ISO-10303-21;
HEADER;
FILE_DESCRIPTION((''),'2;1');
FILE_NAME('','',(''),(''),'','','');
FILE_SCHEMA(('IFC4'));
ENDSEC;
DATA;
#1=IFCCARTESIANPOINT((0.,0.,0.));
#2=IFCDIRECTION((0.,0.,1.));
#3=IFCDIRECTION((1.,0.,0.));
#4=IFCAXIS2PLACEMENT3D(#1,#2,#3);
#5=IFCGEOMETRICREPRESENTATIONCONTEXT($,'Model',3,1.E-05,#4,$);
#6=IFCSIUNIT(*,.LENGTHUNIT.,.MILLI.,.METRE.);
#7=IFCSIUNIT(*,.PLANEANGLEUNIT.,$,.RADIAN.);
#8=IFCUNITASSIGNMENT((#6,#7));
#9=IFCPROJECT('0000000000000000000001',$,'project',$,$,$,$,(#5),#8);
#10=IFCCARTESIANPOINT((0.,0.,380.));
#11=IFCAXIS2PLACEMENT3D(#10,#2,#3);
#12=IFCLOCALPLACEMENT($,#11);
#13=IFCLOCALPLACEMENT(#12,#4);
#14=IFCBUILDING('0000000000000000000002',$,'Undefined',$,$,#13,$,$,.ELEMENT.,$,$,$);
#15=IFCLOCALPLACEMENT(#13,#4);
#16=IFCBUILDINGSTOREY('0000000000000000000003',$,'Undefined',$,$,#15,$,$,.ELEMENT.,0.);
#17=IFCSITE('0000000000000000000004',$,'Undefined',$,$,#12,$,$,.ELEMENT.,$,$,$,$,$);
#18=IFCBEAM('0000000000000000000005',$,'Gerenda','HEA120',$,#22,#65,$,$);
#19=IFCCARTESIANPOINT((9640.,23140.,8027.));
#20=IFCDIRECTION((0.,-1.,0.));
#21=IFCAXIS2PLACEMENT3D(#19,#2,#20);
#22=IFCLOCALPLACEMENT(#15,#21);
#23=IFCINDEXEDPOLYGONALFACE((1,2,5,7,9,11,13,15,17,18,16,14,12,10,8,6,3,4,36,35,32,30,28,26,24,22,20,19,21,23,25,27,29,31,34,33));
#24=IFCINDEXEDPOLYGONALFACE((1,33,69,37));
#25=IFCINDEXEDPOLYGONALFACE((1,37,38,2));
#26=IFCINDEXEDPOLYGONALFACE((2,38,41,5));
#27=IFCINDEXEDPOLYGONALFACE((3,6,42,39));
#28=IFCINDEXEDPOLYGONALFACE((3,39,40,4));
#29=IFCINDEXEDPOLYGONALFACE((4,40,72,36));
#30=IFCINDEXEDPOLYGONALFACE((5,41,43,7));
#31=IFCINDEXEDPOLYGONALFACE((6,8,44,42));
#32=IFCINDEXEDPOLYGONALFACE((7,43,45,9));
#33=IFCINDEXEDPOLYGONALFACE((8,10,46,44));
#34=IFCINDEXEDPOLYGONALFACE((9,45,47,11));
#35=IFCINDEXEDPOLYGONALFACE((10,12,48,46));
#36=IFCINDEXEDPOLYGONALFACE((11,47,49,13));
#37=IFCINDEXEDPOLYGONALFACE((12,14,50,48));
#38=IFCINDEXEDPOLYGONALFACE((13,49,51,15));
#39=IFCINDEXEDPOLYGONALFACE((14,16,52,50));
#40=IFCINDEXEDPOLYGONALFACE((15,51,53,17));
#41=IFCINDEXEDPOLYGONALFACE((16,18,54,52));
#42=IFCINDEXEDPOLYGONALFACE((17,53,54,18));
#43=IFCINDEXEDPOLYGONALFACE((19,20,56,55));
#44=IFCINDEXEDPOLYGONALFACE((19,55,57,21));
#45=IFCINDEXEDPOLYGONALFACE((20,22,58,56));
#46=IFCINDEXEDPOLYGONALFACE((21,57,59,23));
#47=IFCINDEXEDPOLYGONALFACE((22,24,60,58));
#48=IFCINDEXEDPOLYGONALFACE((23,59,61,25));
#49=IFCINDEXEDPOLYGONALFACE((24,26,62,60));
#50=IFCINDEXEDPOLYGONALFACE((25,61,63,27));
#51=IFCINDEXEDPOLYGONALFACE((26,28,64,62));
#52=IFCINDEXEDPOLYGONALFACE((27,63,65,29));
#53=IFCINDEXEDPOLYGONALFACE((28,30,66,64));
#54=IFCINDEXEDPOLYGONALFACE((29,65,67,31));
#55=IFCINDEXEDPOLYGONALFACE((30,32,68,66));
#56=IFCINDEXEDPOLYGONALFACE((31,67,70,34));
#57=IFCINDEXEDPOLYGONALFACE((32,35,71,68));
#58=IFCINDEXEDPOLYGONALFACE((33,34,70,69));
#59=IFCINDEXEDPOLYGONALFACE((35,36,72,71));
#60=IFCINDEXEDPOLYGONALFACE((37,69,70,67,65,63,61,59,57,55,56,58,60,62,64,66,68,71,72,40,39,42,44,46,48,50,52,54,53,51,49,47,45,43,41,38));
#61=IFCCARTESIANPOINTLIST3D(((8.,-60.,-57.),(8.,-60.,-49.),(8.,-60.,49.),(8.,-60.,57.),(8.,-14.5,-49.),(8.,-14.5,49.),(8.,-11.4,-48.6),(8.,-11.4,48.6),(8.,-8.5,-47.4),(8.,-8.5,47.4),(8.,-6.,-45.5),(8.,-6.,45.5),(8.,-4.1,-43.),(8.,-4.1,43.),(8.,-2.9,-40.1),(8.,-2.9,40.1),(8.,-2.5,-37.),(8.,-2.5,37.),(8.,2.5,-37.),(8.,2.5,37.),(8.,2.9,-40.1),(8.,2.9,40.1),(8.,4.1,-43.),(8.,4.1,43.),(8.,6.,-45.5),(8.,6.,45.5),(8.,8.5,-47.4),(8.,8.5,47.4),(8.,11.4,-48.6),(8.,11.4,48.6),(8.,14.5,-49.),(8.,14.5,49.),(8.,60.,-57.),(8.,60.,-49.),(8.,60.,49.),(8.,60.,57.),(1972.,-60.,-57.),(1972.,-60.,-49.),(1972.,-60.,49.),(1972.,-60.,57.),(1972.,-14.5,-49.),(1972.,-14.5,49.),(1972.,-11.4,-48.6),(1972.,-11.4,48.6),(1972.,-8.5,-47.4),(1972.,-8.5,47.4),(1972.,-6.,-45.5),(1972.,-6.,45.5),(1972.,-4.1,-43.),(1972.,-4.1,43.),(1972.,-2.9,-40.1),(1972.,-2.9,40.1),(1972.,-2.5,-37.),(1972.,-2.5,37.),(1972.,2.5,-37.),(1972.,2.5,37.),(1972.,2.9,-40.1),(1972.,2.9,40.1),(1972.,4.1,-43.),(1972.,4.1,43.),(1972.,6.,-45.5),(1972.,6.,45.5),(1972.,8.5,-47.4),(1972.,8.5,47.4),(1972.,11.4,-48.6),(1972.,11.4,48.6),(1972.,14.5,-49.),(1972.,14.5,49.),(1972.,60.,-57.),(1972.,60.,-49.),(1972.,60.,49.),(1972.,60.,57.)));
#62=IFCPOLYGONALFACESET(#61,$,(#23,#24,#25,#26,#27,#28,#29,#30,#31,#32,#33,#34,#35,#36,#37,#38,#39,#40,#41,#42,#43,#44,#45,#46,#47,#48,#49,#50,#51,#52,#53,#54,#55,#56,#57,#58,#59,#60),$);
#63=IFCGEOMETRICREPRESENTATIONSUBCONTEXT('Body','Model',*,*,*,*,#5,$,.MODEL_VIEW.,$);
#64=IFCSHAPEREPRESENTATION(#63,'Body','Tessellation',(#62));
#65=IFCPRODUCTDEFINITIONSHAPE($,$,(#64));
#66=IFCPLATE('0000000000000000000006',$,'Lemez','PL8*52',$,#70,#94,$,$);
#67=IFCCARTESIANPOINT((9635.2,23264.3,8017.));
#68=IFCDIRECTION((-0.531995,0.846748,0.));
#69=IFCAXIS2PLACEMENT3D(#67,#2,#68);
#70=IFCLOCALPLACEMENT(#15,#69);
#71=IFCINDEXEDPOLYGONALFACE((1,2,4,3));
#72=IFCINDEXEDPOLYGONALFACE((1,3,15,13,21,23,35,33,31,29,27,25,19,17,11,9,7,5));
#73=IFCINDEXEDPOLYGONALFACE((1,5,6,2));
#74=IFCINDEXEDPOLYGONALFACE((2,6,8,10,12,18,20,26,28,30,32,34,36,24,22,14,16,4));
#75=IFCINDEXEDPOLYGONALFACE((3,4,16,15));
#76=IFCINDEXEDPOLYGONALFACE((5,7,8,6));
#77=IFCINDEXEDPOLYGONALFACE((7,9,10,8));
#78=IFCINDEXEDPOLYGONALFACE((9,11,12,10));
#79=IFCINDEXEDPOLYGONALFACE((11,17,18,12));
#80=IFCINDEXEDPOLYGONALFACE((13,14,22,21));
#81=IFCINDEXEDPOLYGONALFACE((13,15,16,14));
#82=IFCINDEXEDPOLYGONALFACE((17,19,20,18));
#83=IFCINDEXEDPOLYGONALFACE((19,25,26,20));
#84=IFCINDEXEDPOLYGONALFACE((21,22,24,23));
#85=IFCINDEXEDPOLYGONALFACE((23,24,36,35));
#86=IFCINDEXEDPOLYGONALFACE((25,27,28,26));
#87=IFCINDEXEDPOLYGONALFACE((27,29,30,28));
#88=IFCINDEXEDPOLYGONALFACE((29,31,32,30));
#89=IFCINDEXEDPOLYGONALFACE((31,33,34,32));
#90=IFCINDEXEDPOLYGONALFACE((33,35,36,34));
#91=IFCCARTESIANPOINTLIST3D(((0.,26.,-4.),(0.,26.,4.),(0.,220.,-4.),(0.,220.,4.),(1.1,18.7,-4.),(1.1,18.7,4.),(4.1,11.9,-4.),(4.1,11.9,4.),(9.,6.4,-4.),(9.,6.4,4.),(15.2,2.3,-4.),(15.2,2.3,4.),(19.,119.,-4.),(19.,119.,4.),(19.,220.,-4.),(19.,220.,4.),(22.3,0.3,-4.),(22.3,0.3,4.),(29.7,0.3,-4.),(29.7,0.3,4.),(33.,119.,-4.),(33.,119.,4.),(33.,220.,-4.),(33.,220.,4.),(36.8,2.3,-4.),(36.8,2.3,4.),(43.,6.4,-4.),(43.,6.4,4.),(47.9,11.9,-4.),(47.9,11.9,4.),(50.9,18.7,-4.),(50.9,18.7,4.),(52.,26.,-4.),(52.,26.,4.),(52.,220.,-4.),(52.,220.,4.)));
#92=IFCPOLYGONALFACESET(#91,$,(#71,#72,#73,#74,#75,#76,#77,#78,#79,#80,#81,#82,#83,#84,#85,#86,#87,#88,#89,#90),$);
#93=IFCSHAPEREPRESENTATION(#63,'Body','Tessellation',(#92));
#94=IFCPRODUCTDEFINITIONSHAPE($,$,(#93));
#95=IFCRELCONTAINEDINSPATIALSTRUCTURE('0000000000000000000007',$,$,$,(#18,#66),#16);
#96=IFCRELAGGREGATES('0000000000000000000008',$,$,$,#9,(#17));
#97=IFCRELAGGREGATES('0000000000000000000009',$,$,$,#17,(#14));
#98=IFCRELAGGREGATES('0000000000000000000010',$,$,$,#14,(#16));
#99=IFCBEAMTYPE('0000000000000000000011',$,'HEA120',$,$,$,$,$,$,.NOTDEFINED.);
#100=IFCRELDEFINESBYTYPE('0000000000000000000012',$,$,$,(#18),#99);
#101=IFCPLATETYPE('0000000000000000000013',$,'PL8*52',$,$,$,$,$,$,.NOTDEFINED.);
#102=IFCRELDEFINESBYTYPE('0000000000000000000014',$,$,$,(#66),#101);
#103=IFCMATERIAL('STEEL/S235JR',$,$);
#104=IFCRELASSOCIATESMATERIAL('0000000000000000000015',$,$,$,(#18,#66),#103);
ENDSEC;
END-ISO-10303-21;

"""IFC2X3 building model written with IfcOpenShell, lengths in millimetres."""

from ifc_helpers import new_model, si_unit, frame, frame_2d, origin_with_axes, origin_2d_with_axis, place, context, subcontext, project, spatial, polyline, circle_curve, parameter, trimmed, segment, composite_curve, rectangle, i_section, outline, extrude, boolean, clip, halfspace, material, type_object, element, save


model = new_model("IFC2X3")

# Units and contexts
model_context = context("Model", 3, precision=1e-05, world=origin_with_axes())
body_context = subcontext(model_context, "Body", "Model", "MODEL_VIEW")
ifc_project = project(units=[si_unit("LENGTHUNIT", "METRE", prefix="MILLI"), si_unit("PLANEANGLEUNIT", "RADIAN")], contexts=[model_context])

# Site, building, storey
site_placement = place(None, frame((0.0, 0.0, 380.0), z_axis=(0.0, 0.0, 1.0), x_axis=(1.0, 0.0, 0.0)))
site = spatial("IfcSite", under=ifc_project, at=site_placement, Name="Undefined", CompositionType="ELEMENT")
building_placement = place(site_placement, origin_with_axes())
building = spatial("IfcBuilding", under=site, at=building_placement, Name="Undefined", CompositionType="ELEMENT")
storey_placement = place(building_placement, origin_with_axes())
storey = spatial("IfcBuildingStorey", under=building, at=storey_placement, Name="Undefined", CompositionType="ELEMENT", Elevation=0.0)

# Shared definitions
ifc_material_1 = material(Name="STEEL/S235JR")

# Beam
beam_type_1 = type_object("IfcBeamType", Name="HEA120", PredefinedType="NOTDEFINED")
beam_1_placement = place(storey_placement, frame((9640.0, 23140.0, 8027.0), z_axis=(0.0, 0.0, 1.0), x_axis=(0.0, -1.0, 0.0)))
element("IfcBeam", 1, at=beam_1_placement, inside=storey, type_object=beam_type_1, material=ifc_material_1, Name="Gerenda", Description="HEA120", context=body_context, shape_type="Clipping", body=[
    clip(clip(extrude(i_section(OverallWidth=120.0, OverallDepth=114.0, WebThickness=5.0, FlangeThickness=8.0, FilletRadius=12.0, at=origin_2d_with_axis()), frame((1980.0, 0.0, 0.0), z_axis=(-1.0, 0.0, 0.0), x_axis=(0.0, -1.0, 0.0)), (0.0, 0.0, 1.0), 1980.0), halfspace(frame((1972.0, 0.0, -57.0), z_axis=(-1.0, 0.0, 0.0), x_axis=(0.0, 1.0, 0.0)), True)), halfspace(frame((8.0, 0.0, -57.0), z_axis=(1.0, 0.0, 0.0), x_axis=(0.0, -1.0, 0.0)), True)),
])

# Plate
plate_type_1 = type_object("IfcPlateType", Name="PL8*52", PredefinedType="NOTDEFINED")
plate_1_placement = place(storey_placement, frame((9635.2, 23264.3, 8017.0), z_axis=(0.0, 0.0, 1.0), x_axis=(-0.531995, 0.846748, 0.0)))
element("IfcPlate", 2, at=plate_1_placement, inside=storey, type_object=plate_type_1, material=ifc_material_1, Name="Lemez", Description="PL8*52", context=body_context, shape_type="CSG", body=[
    boolean("DIFFERENCE", extrude(outline(composite_curve([segment(trimmed(circle_curve(frame_2d((26.0, 26.0), x_axis=(-1.0, 0.0)), 26.0), [parameter(0.0)], [parameter(1.570796)], True, "PARAMETER"), True, "CONTINUOUS"), segment(trimmed(circle_curve(frame_2d((26.0, 26.0), x_axis=(0.0, -1.0)), 26.0), [parameter(0.0)], [parameter(1.570796)], True, "PARAMETER"), True, "CONTINUOUS"), segment(polyline([(52.0, 26.0), (52.0, 220.0), (0.0, 220.0), (0.0, 26.0)]), True, "CONTINUOUS")], self_intersect=True)), frame((0.0, 0.0, -4.0), z_axis=(0.0, 0.0, 1.0), x_axis=(1.0, 0.0, 0.0)), (0.0, 0.0, 1.0), 8.0), extrude(rectangle(XDim=14.0, YDim=14.0, at=origin_2d_with_axis()), frame((26.0, 320.0, 0.0), z_axis=(0.0, -1.0, 0.0), x_axis=(1.0, 0.0, 0.0)), (0.0, 0.0, 1.0), 201.0)),
])

save(model, "model.ifc")
